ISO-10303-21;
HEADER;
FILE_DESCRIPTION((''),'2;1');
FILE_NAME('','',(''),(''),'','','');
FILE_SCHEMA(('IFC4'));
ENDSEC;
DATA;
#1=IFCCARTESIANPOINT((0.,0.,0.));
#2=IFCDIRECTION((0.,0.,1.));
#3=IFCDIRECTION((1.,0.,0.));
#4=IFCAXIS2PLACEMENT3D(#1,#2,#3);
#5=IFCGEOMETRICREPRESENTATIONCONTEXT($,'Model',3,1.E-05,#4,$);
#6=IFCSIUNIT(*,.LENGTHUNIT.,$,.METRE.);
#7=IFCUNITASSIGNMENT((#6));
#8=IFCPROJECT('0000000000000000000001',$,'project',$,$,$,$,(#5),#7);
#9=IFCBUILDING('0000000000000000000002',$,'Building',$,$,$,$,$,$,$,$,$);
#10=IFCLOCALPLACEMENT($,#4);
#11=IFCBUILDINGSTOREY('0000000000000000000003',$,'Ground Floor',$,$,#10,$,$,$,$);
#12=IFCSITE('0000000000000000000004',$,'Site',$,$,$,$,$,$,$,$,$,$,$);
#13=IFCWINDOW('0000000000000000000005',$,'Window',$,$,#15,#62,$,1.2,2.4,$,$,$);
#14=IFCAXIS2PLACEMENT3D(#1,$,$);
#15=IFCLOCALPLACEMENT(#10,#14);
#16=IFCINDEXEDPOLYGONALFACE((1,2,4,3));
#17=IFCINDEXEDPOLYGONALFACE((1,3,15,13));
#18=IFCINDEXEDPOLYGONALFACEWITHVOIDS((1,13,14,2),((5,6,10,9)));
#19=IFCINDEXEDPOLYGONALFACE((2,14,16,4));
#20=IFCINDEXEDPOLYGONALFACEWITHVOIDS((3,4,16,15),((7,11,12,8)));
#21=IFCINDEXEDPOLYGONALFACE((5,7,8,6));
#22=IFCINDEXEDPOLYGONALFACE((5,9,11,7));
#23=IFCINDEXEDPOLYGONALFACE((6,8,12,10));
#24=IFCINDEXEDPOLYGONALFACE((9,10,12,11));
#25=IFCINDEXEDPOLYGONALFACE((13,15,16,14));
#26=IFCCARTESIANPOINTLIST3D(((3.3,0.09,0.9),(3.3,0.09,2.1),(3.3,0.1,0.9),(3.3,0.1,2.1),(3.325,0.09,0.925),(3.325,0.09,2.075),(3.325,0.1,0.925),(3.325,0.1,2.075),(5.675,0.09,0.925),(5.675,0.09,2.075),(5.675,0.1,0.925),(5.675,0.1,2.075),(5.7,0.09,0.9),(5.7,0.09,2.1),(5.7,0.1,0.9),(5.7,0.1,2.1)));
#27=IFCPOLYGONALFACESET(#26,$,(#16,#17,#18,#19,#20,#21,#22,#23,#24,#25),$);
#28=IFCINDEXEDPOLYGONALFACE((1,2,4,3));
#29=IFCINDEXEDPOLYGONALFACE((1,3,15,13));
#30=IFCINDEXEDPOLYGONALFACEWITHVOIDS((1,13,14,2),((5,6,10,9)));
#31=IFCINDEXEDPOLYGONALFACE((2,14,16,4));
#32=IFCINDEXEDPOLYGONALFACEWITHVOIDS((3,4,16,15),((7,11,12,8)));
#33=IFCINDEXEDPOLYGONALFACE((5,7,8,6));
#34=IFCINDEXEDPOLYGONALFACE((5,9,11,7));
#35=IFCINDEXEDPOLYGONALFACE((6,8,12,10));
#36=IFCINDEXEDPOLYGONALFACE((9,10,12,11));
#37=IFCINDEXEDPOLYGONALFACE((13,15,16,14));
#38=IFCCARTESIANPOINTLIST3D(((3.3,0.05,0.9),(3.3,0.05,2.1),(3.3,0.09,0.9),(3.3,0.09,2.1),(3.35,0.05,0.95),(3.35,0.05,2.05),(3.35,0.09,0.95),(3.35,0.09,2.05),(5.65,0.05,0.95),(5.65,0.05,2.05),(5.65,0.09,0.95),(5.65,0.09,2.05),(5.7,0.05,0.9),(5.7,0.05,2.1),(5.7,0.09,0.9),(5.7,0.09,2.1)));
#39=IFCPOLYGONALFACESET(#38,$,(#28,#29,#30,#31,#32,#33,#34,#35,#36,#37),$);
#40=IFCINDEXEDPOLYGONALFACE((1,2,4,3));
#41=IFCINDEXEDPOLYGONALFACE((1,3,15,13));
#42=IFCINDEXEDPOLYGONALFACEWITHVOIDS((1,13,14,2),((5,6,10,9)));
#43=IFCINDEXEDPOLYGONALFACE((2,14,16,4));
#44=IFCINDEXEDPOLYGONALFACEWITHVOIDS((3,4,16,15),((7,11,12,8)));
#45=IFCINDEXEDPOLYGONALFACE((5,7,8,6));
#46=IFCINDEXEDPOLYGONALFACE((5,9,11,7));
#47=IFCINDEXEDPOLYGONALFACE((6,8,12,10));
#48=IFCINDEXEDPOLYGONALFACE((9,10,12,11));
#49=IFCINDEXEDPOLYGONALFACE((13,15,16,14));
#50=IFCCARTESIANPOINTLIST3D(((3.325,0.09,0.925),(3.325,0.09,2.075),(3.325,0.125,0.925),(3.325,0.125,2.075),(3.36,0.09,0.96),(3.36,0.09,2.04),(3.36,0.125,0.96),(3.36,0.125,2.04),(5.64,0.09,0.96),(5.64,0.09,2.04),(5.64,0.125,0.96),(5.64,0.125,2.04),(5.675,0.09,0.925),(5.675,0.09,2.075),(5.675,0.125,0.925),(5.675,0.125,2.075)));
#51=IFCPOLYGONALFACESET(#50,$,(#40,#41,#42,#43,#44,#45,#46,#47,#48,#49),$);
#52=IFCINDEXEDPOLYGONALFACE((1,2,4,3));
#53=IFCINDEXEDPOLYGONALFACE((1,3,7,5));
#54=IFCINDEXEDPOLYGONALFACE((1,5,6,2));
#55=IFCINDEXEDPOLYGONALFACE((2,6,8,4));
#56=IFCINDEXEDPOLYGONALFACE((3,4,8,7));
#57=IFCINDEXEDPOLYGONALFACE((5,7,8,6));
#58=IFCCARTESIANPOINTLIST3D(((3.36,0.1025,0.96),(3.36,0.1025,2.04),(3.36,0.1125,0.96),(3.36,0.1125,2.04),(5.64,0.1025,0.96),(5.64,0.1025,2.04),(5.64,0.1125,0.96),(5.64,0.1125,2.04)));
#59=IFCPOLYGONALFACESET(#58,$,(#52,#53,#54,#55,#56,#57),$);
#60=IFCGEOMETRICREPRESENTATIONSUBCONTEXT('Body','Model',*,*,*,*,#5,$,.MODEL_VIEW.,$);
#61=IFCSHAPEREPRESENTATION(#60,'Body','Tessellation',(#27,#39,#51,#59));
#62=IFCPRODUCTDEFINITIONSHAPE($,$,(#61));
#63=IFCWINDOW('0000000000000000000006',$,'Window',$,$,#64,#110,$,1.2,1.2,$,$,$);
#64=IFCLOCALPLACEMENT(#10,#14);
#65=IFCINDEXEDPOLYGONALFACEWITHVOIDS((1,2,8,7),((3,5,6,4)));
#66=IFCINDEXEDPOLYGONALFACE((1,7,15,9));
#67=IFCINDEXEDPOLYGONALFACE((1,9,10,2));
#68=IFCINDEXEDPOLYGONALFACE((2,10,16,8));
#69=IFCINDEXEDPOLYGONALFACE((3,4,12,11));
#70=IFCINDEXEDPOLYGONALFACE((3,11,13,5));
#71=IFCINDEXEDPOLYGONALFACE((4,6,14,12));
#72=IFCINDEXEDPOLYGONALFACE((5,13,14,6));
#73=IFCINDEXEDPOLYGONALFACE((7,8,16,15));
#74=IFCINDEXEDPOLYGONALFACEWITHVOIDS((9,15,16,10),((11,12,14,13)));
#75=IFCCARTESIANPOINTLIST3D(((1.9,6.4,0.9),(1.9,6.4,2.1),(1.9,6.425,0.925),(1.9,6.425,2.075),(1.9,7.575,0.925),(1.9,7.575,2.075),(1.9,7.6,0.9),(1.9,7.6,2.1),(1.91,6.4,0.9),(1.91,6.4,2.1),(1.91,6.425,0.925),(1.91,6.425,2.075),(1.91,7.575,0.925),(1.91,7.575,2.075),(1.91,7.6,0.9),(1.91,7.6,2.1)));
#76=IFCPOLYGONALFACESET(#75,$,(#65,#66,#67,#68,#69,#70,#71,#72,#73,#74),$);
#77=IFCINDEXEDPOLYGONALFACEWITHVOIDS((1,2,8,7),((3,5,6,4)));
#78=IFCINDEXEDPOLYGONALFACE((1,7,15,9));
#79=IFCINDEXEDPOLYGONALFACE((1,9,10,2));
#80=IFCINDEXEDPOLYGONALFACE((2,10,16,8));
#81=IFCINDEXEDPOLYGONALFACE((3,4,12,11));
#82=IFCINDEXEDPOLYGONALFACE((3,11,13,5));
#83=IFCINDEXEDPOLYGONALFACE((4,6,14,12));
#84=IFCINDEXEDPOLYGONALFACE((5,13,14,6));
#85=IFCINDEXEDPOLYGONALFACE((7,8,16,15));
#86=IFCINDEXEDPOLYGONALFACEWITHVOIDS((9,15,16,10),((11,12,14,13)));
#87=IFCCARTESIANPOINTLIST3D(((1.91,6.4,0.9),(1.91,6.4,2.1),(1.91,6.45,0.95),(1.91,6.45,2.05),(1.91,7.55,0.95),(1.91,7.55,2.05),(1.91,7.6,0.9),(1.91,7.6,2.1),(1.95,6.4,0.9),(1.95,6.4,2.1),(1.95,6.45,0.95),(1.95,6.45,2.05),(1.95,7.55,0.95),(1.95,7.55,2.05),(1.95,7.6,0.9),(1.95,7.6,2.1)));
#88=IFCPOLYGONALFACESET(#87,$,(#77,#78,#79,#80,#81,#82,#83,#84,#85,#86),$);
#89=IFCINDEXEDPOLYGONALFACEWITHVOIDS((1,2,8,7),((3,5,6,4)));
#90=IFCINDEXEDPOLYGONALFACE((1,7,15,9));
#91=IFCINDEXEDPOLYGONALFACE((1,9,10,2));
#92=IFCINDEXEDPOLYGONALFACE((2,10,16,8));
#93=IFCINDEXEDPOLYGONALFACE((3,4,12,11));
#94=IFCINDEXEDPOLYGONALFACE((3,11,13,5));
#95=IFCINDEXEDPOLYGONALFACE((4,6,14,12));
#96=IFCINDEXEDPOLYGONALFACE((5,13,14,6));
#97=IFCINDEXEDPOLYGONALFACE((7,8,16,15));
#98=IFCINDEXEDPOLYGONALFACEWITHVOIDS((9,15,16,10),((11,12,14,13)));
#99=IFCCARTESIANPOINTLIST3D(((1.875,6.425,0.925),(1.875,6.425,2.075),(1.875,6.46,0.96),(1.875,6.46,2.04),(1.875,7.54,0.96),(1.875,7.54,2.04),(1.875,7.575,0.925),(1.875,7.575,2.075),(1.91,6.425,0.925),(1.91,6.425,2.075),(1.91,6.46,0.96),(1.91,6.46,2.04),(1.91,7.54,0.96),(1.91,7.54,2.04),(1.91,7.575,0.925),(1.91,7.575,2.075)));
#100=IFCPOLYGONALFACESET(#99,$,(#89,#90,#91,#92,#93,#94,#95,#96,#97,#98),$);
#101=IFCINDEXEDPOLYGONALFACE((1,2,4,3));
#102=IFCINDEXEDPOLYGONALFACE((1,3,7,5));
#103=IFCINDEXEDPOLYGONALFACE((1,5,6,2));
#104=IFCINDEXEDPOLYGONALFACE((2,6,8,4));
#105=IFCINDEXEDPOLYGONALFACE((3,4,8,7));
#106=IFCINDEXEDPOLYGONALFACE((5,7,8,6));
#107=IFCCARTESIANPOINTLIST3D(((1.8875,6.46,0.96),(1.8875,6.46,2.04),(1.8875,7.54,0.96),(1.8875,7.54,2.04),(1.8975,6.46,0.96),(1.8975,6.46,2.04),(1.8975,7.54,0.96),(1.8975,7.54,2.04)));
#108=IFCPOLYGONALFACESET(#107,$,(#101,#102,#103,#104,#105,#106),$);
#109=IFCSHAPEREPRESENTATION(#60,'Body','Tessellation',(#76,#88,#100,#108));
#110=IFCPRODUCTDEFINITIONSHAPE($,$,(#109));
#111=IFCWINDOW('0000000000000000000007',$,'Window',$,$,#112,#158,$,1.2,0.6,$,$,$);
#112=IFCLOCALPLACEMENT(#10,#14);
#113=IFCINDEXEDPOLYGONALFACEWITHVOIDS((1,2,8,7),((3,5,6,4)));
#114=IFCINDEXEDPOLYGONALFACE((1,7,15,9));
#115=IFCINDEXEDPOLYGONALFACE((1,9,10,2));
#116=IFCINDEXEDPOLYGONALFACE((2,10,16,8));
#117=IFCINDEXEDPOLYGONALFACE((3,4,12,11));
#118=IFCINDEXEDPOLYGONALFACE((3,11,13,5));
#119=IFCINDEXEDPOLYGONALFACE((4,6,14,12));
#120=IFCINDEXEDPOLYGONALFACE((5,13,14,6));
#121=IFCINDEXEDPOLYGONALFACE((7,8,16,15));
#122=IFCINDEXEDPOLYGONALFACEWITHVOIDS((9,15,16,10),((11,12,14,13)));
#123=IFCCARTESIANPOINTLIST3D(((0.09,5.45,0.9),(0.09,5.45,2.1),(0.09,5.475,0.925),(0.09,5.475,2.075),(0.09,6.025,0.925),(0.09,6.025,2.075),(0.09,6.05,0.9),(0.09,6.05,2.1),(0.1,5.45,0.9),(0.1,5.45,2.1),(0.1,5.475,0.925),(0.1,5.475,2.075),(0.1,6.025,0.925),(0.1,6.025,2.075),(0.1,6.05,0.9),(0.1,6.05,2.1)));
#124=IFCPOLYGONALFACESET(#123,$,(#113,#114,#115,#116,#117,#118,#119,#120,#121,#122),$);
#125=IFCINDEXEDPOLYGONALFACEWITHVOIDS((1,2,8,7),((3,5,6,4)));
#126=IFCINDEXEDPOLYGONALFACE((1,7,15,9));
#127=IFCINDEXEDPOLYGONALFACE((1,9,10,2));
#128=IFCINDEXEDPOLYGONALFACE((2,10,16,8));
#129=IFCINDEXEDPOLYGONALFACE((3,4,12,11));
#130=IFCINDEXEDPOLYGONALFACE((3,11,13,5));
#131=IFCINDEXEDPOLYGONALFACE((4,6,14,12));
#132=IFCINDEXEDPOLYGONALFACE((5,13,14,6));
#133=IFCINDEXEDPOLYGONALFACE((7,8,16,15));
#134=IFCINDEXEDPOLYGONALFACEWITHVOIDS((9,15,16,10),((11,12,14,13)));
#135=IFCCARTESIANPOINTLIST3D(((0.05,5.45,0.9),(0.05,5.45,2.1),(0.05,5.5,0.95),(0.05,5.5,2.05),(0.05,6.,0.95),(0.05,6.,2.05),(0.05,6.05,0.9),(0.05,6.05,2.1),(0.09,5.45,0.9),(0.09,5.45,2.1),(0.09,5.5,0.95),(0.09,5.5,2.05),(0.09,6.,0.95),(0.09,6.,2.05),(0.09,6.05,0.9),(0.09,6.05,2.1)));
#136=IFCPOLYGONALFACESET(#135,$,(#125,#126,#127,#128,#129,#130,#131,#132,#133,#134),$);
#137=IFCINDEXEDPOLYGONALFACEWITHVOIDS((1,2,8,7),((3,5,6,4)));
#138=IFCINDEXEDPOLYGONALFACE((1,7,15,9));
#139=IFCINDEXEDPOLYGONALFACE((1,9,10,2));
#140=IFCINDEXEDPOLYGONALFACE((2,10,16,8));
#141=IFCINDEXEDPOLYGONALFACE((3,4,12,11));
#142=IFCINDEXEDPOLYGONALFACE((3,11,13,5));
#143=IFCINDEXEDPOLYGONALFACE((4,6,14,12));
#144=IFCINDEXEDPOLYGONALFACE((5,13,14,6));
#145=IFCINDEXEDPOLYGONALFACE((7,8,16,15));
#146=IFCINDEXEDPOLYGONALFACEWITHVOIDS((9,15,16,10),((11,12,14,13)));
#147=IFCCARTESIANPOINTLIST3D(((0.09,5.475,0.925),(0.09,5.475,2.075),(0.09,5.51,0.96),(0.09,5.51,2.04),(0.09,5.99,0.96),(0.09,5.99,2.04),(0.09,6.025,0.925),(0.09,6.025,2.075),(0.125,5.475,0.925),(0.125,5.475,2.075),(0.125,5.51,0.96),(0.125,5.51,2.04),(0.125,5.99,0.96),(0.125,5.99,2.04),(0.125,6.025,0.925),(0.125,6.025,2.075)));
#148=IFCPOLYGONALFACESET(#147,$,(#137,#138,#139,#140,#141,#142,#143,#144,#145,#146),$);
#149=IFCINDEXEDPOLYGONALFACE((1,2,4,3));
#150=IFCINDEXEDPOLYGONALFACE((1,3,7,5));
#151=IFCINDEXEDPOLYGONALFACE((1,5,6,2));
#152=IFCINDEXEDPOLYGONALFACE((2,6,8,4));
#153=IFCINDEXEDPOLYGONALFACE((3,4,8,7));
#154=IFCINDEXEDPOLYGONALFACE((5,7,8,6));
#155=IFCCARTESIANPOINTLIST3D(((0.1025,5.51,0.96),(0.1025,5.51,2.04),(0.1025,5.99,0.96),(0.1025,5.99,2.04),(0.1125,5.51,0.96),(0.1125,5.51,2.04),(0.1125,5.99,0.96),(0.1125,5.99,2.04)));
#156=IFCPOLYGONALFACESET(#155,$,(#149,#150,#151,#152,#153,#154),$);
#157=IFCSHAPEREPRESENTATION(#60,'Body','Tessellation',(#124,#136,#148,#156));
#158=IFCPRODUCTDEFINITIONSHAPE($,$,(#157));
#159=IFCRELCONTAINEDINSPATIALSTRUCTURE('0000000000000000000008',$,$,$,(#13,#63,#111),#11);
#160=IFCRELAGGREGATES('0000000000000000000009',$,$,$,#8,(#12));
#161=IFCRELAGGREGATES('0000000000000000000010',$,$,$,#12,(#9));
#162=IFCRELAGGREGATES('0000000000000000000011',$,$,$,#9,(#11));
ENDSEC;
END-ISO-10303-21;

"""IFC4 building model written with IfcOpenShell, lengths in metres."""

from ifc_helpers import new_model, si_unit, frame, origin_with_axes, place, context, subcontext, project, spatial, line, indexed_curve, outline, extrude, element, save


model = new_model("IFC4")

# Units and contexts
model_context = context("Model", 3, precision=1e-05, world=origin_with_axes())
body_context = subcontext(model_context, "Body", "Model", "MODEL_VIEW")
ifc_project = project(units=[si_unit("LENGTHUNIT", "METRE")], contexts=[model_context])

# Site, building, storey
site = spatial("IfcSite", under=ifc_project, Name="Site")
building = spatial("IfcBuilding", under=site, Name="Building")
storey_placement = place(None, origin_with_axes())
storey = spatial("IfcBuildingStorey", under=building, at=storey_placement, Name="Ground Floor")

# Windows
window_1_placement = place(storey_placement, frame((3.3, 0.0, 0.9), z_axis=(0.0, 0.0, 1.0), x_axis=(1.0, 0.0, 0.0)))
element("IfcWindow", 1, at=window_1_placement, inside=storey, Name="Window", OverallHeight=1.2, OverallWidth=2.4, context=body_context, shape_type="SweptSolid", body=[
    extrude(outline(indexed_curve([(0.0, 0.0), (2.4, 0.0), (2.4, 1.2), (0.0, 1.2)], segments=[line(1, 2, 3, 4, 1)]), holes=[indexed_curve([(0.025, 0.025), (2.375, 0.025), (2.375, 1.175), (0.025, 1.175)], segments=[line(1, 2, 3, 4, 1)])]), frame((0.0, 0.09, 0.0), z_axis=(0.0, -1.0, 0.0), x_axis=(1.0, 0.0, 0.0)), (0.0, 0.0, -1.0), 0.01),
    extrude(outline(indexed_curve([(0.0, 0.0), (2.4, 0.0), (2.4, 1.2), (0.0, 1.2)], segments=[line(1, 2, 3, 4, 1)]), holes=[indexed_curve([(0.05, 0.05), (2.35, 0.05), (2.35, 1.15), (0.05, 1.15)], segments=[line(1, 2, 3, 4, 1)])]), frame((0.0, 0.05, 0.0), z_axis=(0.0, -1.0, 0.0), x_axis=(1.0, 0.0, 0.0)), (0.0, 0.0, -1.0), 0.04),
    extrude(outline(indexed_curve([(0.0, 0.0), (2.35, 0.0), (2.35, 1.15), (0.0, 1.15)], segments=[line(1, 2, 3, 4, 1)]), holes=[indexed_curve([(0.035, 0.035), (2.315, 0.035), (2.315, 1.115), (0.035, 1.115)], segments=[line(1, 2, 3, 4, 1)])]), frame((0.025, 0.09, 0.025), z_axis=(0.0, -1.0, 0.0), x_axis=(1.0, 0.0, 0.0)), (0.0, 0.0, -1.0), 0.035),
    extrude(outline(indexed_curve([(0.035, 0.035), (2.315, 0.035), (2.315, 1.115), (0.035, 1.115)], segments=[line(1, 2, 3, 4, 1)])), frame((0.025, 0.1025, 0.025), z_axis=(0.0, -1.0, 0.0), x_axis=(1.0, 0.0, 0.0)), (0.0, 0.0, -1.0), 0.01),
])
window_2_placement = place(storey_placement, frame((2.0, 6.4, 0.9), z_axis=(0.0, 0.0, 1.0), x_axis=(0.0, 1.0, 0.0)))
element("IfcWindow", 2, at=window_2_placement, inside=storey, Name="Window", OverallHeight=1.2, OverallWidth=1.2, context=body_context, shape_type="SweptSolid", body=[
    extrude(outline(indexed_curve([(0.0, 0.0), (1.2, 0.0), (1.2, 1.2), (0.0, 1.2)], segments=[line(1, 2, 3, 4, 1)]), holes=[indexed_curve([(0.025, 0.025), (1.175, 0.025), (1.175, 1.175), (0.025, 1.175)], segments=[line(1, 2, 3, 4, 1)])]), frame((0.0, 0.09, 0.0), z_axis=(0.0, -1.0, 0.0), x_axis=(1.0, 0.0, 0.0)), (0.0, 0.0, -1.0), 0.01),
    extrude(outline(indexed_curve([(0.0, 0.0), (1.2, 0.0), (1.2, 1.2), (0.0, 1.2)], segments=[line(1, 2, 3, 4, 1)]), holes=[indexed_curve([(0.05, 0.05), (1.15, 0.05), (1.15, 1.15), (0.05, 1.15)], segments=[line(1, 2, 3, 4, 1)])]), frame((0.0, 0.05, 0.0), z_axis=(0.0, -1.0, 0.0), x_axis=(1.0, 0.0, 0.0)), (0.0, 0.0, -1.0), 0.04),
    extrude(outline(indexed_curve([(0.0, 0.0), (1.15, 0.0), (1.15, 1.15), (0.0, 1.15)], segments=[line(1, 2, 3, 4, 1)]), holes=[indexed_curve([(0.035, 0.035), (1.115, 0.035), (1.115, 1.115), (0.035, 1.115)], segments=[line(1, 2, 3, 4, 1)])]), frame((0.025, 0.09, 0.025), z_axis=(0.0, -1.0, 0.0), x_axis=(1.0, 0.0, 0.0)), (0.0, 0.0, -1.0), 0.035),
    extrude(outline(indexed_curve([(0.035, 0.035), (1.115, 0.035), (1.115, 1.115), (0.035, 1.115)], segments=[line(1, 2, 3, 4, 1)])), frame((0.025, 0.1025, 0.025), z_axis=(0.0, -1.0, 0.0), x_axis=(1.0, 0.0, 0.0)), (0.0, 0.0, -1.0), 0.01),
])
window_3_placement = place(storey_placement, frame((0.0, 6.05, 0.9), z_axis=(0.0, 0.0, 1.0), x_axis=(0.0, -1.0, 0.0)))
element("IfcWindow", 3, at=window_3_placement, inside=storey, Name="Window", OverallHeight=1.2, OverallWidth=0.6, context=body_context, shape_type="SweptSolid", body=[
    extrude(outline(indexed_curve([(0.0, 0.0), (0.6, 0.0), (0.6, 1.2), (0.0, 1.2)], segments=[line(1, 2, 3, 4, 1)]), holes=[indexed_curve([(0.025, 0.025), (0.575, 0.025), (0.575, 1.175), (0.025, 1.175)], segments=[line(1, 2, 3, 4, 1)])]), frame((0.0, 0.09, 0.0), z_axis=(0.0, -1.0, 0.0), x_axis=(1.0, 0.0, 0.0)), (0.0, 0.0, -1.0), 0.01),
    extrude(outline(indexed_curve([(0.0, 0.0), (0.6, 0.0), (0.6, 1.2), (0.0, 1.2)], segments=[line(1, 2, 3, 4, 1)]), holes=[indexed_curve([(0.05, 0.05), (0.55, 0.05), (0.55, 1.15), (0.05, 1.15)], segments=[line(1, 2, 3, 4, 1)])]), frame((0.0, 0.05, 0.0), z_axis=(0.0, -1.0, 0.0), x_axis=(1.0, 0.0, 0.0)), (0.0, 0.0, -1.0), 0.04),
    extrude(outline(indexed_curve([(0.0, 0.0), (0.55, 0.0), (0.55, 1.15), (0.0, 1.15)], segments=[line(1, 2, 3, 4, 1)]), holes=[indexed_curve([(0.035, 0.035), (0.515, 0.035), (0.515, 1.115), (0.035, 1.115)], segments=[line(1, 2, 3, 4, 1)])]), frame((0.025, 0.09, 0.025), z_axis=(0.0, -1.0, 0.0), x_axis=(1.0, 0.0, 0.0)), (0.0, 0.0, -1.0), 0.035),
    extrude(outline(indexed_curve([(0.035, 0.035), (0.515, 0.035), (0.515, 1.115), (0.035, 1.115)], segments=[line(1, 2, 3, 4, 1)])), frame((0.025, 0.1025, 0.025), z_axis=(0.0, -1.0, 0.0), x_axis=(1.0, 0.0, 0.0)), (0.0, 0.0, -1.0), 0.01),
])

save(model, "model.ifc")
